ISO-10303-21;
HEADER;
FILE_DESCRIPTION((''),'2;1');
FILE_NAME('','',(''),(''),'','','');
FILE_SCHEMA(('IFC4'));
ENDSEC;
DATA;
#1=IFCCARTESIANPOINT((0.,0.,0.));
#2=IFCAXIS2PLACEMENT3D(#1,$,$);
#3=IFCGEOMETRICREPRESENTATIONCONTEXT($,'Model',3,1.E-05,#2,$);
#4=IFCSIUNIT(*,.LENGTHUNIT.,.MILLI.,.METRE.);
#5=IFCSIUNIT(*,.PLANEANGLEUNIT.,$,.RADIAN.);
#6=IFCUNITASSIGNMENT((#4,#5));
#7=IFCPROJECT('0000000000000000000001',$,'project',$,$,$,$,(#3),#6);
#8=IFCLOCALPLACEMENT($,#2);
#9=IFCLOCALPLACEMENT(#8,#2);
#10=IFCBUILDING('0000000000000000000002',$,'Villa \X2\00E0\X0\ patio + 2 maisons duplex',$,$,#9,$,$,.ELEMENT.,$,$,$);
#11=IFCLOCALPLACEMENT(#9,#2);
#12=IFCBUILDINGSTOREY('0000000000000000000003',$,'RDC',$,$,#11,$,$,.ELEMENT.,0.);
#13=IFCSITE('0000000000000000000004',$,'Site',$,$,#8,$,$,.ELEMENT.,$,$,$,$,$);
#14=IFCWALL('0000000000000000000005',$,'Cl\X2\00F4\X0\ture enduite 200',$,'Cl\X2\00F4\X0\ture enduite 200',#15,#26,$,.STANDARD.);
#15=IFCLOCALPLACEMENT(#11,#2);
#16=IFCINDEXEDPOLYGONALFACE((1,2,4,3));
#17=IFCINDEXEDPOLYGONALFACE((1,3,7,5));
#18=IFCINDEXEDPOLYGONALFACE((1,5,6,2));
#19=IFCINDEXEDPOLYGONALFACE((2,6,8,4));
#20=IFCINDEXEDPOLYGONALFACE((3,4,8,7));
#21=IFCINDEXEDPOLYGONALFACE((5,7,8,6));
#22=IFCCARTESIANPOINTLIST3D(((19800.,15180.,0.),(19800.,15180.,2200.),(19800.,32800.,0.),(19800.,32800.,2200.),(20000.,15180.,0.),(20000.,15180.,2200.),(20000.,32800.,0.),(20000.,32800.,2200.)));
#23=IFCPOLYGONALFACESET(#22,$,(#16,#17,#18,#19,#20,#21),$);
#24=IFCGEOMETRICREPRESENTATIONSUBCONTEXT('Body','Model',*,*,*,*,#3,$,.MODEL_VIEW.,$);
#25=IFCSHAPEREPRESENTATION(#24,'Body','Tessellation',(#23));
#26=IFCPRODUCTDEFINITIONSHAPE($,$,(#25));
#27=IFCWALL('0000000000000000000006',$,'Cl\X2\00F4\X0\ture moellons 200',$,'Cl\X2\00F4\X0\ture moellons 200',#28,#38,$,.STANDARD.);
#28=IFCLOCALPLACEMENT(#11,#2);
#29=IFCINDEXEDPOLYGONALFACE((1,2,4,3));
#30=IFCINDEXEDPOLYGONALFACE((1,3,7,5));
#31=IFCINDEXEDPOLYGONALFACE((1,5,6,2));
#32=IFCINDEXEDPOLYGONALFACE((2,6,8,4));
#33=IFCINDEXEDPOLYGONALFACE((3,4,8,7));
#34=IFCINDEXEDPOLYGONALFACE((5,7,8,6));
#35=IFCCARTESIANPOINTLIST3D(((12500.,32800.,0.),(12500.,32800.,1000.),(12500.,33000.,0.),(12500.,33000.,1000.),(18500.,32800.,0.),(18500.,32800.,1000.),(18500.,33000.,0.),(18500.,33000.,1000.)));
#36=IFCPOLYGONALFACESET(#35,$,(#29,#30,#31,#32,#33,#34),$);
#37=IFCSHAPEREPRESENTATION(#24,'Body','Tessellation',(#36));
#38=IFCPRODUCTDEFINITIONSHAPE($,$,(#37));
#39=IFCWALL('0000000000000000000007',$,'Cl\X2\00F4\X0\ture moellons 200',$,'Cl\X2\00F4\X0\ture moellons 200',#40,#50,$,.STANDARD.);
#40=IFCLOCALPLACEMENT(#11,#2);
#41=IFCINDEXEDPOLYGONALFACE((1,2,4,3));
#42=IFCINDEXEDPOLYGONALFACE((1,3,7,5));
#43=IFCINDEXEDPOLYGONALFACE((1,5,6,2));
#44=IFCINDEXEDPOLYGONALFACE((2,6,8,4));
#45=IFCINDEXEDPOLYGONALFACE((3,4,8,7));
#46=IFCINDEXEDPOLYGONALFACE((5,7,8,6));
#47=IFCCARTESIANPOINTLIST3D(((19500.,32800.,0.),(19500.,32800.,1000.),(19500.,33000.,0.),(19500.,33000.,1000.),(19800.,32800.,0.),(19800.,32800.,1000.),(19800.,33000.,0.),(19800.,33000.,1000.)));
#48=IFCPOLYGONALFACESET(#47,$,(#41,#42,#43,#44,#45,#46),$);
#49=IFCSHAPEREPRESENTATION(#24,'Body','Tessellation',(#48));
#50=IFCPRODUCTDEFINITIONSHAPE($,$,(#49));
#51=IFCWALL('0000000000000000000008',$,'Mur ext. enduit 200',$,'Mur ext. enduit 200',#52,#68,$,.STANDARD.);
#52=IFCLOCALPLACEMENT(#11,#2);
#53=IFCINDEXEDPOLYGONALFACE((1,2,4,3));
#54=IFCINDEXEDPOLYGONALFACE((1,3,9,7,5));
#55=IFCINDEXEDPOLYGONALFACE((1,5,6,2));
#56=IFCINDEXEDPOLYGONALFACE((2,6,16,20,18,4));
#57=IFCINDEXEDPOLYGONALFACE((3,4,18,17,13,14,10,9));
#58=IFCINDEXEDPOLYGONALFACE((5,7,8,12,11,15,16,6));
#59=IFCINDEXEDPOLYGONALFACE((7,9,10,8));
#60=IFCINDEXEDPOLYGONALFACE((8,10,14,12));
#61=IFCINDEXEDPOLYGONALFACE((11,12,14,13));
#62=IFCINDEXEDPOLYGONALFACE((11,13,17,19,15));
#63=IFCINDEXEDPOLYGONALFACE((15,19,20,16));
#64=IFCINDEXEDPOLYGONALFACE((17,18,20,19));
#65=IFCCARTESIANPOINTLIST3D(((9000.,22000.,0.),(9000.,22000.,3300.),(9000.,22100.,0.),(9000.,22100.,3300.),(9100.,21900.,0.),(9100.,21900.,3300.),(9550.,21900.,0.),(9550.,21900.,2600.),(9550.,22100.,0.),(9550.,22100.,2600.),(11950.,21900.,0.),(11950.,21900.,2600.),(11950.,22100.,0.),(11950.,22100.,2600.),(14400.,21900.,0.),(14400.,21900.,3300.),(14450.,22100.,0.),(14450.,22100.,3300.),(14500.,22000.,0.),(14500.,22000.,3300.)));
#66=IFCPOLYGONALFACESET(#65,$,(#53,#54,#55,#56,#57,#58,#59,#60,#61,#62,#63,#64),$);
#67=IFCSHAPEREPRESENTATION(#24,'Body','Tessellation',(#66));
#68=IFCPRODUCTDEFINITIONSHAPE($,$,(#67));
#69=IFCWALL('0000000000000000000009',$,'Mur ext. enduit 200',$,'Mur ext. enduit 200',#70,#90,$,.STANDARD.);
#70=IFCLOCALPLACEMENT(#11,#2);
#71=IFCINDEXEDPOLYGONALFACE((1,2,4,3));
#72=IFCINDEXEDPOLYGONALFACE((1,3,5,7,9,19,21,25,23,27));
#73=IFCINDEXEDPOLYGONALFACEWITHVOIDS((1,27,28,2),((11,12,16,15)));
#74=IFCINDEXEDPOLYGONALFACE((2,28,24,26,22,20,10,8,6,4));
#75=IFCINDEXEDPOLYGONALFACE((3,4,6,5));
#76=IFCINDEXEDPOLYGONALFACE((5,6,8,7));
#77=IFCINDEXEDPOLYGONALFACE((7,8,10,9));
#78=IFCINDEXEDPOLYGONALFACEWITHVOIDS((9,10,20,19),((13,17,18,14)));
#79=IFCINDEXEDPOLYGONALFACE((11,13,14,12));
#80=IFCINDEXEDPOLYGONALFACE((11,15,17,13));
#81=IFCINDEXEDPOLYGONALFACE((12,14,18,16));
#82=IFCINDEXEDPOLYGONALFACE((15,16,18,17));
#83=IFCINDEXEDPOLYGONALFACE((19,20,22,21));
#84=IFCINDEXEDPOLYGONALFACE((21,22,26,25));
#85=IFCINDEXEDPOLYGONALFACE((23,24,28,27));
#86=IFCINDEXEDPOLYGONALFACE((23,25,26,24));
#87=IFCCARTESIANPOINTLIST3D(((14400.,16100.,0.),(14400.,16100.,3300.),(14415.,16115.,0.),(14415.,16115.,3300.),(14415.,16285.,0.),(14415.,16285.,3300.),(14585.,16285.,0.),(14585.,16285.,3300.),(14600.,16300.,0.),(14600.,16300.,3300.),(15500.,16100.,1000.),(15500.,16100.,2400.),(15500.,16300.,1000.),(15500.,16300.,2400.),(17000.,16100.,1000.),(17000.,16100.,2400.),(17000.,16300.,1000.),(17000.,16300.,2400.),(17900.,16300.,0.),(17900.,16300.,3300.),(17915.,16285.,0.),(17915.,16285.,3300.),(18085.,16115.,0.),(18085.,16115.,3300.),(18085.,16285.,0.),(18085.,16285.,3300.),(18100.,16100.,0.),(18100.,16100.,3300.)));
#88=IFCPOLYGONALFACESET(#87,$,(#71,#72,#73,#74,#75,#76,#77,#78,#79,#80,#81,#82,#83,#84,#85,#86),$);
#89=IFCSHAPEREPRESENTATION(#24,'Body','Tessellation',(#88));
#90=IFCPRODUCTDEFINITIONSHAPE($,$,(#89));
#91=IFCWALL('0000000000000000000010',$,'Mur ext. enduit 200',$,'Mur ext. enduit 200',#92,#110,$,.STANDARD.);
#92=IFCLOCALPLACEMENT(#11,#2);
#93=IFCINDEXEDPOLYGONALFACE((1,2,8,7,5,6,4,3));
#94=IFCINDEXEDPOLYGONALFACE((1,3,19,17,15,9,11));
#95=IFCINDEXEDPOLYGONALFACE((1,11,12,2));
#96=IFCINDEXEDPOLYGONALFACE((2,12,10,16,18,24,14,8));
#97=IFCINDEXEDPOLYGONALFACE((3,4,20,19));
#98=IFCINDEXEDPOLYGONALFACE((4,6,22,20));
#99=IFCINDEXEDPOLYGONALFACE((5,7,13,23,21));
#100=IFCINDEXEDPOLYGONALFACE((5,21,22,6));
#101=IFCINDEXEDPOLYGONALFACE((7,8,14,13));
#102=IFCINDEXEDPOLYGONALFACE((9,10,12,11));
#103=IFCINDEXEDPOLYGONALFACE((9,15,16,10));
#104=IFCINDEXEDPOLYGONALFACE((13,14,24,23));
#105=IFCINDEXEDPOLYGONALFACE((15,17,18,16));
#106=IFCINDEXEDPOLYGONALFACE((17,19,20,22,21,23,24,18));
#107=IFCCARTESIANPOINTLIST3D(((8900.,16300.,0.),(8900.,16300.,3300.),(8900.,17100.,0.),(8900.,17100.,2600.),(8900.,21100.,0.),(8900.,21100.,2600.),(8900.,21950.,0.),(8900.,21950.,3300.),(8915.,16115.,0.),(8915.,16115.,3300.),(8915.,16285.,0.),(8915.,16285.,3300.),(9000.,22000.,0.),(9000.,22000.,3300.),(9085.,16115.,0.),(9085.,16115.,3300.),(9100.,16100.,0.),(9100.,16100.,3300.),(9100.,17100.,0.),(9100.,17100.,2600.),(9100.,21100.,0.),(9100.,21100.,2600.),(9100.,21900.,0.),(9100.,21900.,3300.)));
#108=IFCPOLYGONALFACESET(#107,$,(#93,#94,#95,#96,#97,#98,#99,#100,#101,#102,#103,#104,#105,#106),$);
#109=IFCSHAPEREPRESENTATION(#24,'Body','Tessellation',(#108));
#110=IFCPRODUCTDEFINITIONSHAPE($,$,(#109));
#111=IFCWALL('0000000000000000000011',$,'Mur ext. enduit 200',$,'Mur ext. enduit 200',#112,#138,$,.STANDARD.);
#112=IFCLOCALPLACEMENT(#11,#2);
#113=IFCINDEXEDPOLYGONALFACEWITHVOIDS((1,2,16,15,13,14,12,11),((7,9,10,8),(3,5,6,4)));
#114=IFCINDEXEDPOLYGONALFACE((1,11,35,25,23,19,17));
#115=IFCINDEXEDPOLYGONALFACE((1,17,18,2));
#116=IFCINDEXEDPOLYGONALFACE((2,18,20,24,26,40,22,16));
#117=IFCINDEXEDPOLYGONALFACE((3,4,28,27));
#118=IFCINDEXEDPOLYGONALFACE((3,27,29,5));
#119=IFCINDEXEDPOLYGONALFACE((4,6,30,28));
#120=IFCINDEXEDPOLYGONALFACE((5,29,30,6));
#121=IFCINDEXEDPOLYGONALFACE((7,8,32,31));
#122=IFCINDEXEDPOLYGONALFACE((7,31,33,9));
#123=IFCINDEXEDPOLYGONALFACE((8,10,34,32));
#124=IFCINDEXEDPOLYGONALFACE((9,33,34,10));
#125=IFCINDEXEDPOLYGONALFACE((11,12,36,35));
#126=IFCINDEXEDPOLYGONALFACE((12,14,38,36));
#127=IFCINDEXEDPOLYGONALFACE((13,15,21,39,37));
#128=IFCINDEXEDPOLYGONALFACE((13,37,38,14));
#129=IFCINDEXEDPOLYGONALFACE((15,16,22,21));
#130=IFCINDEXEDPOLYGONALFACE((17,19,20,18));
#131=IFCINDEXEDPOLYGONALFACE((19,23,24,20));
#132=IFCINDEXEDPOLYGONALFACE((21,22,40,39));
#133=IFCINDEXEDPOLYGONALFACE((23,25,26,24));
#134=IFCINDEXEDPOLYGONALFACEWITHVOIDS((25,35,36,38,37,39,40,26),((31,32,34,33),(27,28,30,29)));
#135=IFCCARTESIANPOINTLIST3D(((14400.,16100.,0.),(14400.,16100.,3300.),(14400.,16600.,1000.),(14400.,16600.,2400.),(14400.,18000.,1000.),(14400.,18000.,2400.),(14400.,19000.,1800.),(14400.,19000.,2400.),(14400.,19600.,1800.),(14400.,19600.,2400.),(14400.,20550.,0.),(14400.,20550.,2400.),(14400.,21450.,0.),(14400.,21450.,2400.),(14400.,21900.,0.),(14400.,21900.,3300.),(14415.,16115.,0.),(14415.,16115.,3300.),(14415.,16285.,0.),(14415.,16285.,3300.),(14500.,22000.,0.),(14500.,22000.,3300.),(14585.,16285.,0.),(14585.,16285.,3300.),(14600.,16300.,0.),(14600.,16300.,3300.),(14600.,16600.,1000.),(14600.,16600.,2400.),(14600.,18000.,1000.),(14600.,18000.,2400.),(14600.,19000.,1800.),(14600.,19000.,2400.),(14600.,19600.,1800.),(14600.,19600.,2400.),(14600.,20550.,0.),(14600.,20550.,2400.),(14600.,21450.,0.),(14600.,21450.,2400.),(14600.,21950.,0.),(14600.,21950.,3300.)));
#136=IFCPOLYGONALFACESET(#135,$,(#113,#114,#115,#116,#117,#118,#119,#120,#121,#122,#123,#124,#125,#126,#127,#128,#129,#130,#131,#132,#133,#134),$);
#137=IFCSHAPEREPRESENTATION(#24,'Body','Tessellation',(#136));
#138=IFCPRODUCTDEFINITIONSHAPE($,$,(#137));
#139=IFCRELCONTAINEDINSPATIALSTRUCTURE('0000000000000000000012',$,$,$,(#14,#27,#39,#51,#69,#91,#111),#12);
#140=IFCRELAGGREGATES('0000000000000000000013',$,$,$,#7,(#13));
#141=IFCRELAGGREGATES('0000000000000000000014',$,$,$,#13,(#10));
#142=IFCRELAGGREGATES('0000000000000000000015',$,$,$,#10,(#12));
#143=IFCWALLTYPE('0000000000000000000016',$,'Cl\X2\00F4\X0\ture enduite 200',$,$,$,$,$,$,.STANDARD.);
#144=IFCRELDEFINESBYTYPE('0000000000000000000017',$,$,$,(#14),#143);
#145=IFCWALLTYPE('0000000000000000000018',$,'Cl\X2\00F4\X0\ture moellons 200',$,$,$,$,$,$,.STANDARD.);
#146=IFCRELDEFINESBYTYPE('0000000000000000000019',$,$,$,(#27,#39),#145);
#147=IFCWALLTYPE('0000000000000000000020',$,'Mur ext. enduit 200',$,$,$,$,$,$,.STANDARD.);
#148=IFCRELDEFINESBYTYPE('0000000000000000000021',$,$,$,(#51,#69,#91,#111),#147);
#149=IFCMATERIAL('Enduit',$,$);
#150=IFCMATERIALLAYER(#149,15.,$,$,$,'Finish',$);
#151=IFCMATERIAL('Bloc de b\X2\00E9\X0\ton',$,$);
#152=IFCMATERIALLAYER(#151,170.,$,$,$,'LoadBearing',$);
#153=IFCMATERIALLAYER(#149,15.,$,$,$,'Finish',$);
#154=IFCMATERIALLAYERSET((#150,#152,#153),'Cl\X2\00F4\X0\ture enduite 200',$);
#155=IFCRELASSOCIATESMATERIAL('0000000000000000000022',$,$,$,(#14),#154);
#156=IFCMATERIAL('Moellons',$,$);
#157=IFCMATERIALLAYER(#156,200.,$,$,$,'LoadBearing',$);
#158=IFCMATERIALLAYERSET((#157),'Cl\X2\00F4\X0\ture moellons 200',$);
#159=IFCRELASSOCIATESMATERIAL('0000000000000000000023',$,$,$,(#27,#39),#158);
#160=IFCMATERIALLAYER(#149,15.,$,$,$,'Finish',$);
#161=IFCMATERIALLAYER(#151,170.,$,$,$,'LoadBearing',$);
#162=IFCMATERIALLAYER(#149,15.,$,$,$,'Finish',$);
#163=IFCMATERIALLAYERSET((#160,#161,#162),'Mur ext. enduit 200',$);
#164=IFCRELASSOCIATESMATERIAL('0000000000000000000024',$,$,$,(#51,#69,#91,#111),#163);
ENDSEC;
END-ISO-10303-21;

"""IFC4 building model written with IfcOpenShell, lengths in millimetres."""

from ifc_helpers import new_model, si_unit, frame, frame_2d, origin, place, context, subcontext, project, spatial, polyline, rectangle, outline, extrude, material, layer, layer_set, layer_usage, type_object, element, save


model = new_model("IFC4")

# Units and contexts
model_context = context("Model", 3, precision=1e-05, world=origin())
body_context = subcontext(model_context, "Body", "Model", "MODEL_VIEW")
ifc_project = project(units=[si_unit("LENGTHUNIT", "METRE", prefix="MILLI"), si_unit("PLANEANGLEUNIT", "RADIAN")], contexts=[model_context])

# Site, building, storey
site_placement = place(None, origin())
site = spatial("IfcSite", under=ifc_project, at=site_placement, Name="Site", CompositionType="ELEMENT")
building_placement = place(site_placement, origin())
building = spatial("IfcBuilding", under=site, at=building_placement, Name="Villa à patio + 2 maisons duplex", CompositionType="ELEMENT")
storey_placement = place(building_placement, origin())
storey = spatial("IfcBuildingStorey", under=building, at=storey_placement, Name="RDC", CompositionType="ELEMENT", Elevation=0.0)

# Shared definitions
ifc_material_1 = material(Name="Enduit")
ifc_material_2 = material(Name="Bloc de béton")

# Walls
ifc_layer_1 = layer(ifc_material_1, 15.0, Category="Finish")
ifc_layer_2 = layer(ifc_material_2, 170.0, Category="LoadBearing")
ifc_layer_3 = layer(ifc_material_1, 15.0, Category="Finish")
ifc_layer_set_1 = layer_set([ifc_layer_1, ifc_layer_2, ifc_layer_3], Name="Clôture enduite 200")
ifc_layer_usage_1 = layer_usage(ifc_layer_set_1, "AXIS2", "NEGATIVE", 100.0)
wall_type_1 = type_object("IfcWallType", Name="Clôture enduite 200", PredefinedType="STANDARD")
wall_1_placement = place(storey_placement, frame((19900.0, 33000.0, 0.0), z_axis=(0.0, 0.0, 1.0), x_axis=(0.0, -1.0, 0.0)))
element("IfcWall", 1, at=wall_1_placement, inside=storey, type_object=wall_type_1, material=ifc_layer_usage_1, Name="Clôture enduite 200", ObjectType="Clôture enduite 200", PredefinedType="STANDARD", context=body_context, shape_type="SweptSolid", body=[
    extrude(outline(polyline([(200.0, -100.0), (200.0, 100.0), (17820.0, 100.0), (17820.0, -100.0), (200.0, -100.0)])), origin(), (0.0, 0.0, 1.0), 2200.0),
])
ifc_material_3 = material(Name="Moellons")
ifc_layer_4 = layer(ifc_material_3, 200.0, Category="LoadBearing")
ifc_layer_set_2 = layer_set([ifc_layer_4], Name="Clôture moellons 200")
ifc_layer_usage_2 = layer_usage(ifc_layer_set_2, "AXIS2", "NEGATIVE", 100.0)
wall_type_2 = type_object("IfcWallType", Name="Clôture moellons 200", PredefinedType="STANDARD")
wall_2_placement = place(storey_placement, frame((12500.0, 32900.0, 0.0), z_axis=(0.0, 0.0, 1.0), x_axis=(1.0, 0.0, 0.0)))
element("IfcWall", 2, at=wall_2_placement, inside=storey, type_object=wall_type_2, material=ifc_layer_usage_2, Name="Clôture moellons 200", ObjectType="Clôture moellons 200", PredefinedType="STANDARD", context=body_context, shape_type="SweptSolid", body=[
    extrude(outline(polyline([(0.0, -100.0), (0.0, 100.0), (6000.0, 100.0), (6000.0, -100.0), (0.0, -100.0)])), origin(), (0.0, 0.0, 1.0), 1000.0),
])
wall_3_placement = place(storey_placement, frame((19500.0, 32900.0, 0.0), z_axis=(0.0, 0.0, 1.0), x_axis=(1.0, 0.0, 0.0)))
element("IfcWall", 3, at=wall_3_placement, inside=storey, type_object=wall_type_2, material=ifc_layer_usage_2, Name="Clôture moellons 200", ObjectType="Clôture moellons 200", PredefinedType="STANDARD", context=body_context, shape_type="SweptSolid", body=[
    extrude(outline(polyline([(0.0, -100.0), (0.0, 100.0), (300.0, 100.0), (300.0, -100.0), (0.0, -100.0)])), origin(), (0.0, 0.0, 1.0), 1000.0),
])

# Walls, openings
ifc_layer_5 = layer(ifc_material_1, 15.0, Category="Finish")
ifc_layer_6 = layer(ifc_material_2, 170.0, Category="LoadBearing")
ifc_layer_7 = layer(ifc_material_1, 15.0, Category="Finish")
ifc_layer_set_3 = layer_set([ifc_layer_5, ifc_layer_6, ifc_layer_7], Name="Mur ext. enduit 200")
ifc_layer_usage_3 = layer_usage(ifc_layer_set_3, "AXIS2", "NEGATIVE", 100.0)
wall_type_3 = type_object("IfcWallType", Name="Mur ext. enduit 200", PredefinedType="STANDARD")
wall_4_placement = place(storey_placement, frame((9000.0, 22000.0, 0.0), z_axis=(0.0, 0.0, 1.0), x_axis=(1.0, 0.0, 0.0)))
wall_4 = element("IfcWall", 4, at=wall_4_placement, inside=storey, type_object=wall_type_3, material=ifc_layer_usage_3, Name="Mur ext. enduit 200", ObjectType="Mur ext. enduit 200", PredefinedType="STANDARD", context=body_context, shape_type="SweptSolid", body=[
    extrude(outline(polyline([(100.0, -100.0), (0.0, 0.0), (0.0, 100.0), (5450.0, 100.0), (5500.0, 0.0), (5400.0, -100.0), (100.0, -100.0)])), origin(), (0.0, 0.0, 1.0), 3300.0),
])
opening_1_placement = place(wall_4_placement, frame((550.0, 0.0, 0.0), z_axis=(0.0, 0.0, 1.0), x_axis=(1.0, 0.0, 0.0)))
element("IfcOpeningElement", 5, at=opening_1_placement, cuts=wall_4, PredefinedType="OPENING", context=body_context, shape_type="SweptSolid", body=[
    extrude(rectangle(XDim=2400.0, YDim=220.0, at=frame_2d((1200.0, 0.0))), origin(), (0.0, 0.0, 1.0), 2600.0),
])
wall_5_placement = place(storey_placement, frame((14500.0, 16200.0, 0.0), z_axis=(0.0, 0.0, 1.0), x_axis=(1.0, 0.0, 0.0)))
wall_5 = element("IfcWall", 6, at=wall_5_placement, inside=storey, type_object=wall_type_3, material=ifc_layer_usage_3, Name="Mur ext. enduit 200", ObjectType="Mur ext. enduit 200", PredefinedType="STANDARD", context=body_context, shape_type="SweptSolid", body=[
    extrude(outline(polyline([(-100.0, -100.0), (-85.0, -85.0), (-85.0, 85.0), (85.0, 85.0), (100.0, 100.0), (3400.0, 100.0), (3415.0, 85.0), (3585.0, 85.0), (3585.0, -85.0), (3600.0, -100.0), (-100.0, -100.0)])), origin(), (0.0, 0.0, 1.0), 3300.0),
])
opening_2_placement = place(wall_5_placement, frame((1000.0, 0.0, 1000.0), z_axis=(0.0, 0.0, 1.0), x_axis=(1.0, 0.0, 0.0)))
element("IfcOpeningElement", 7, at=opening_2_placement, cuts=wall_5, PredefinedType="OPENING", context=body_context, shape_type="SweptSolid", body=[
    extrude(rectangle(XDim=1500.0, YDim=220.0, at=frame_2d((750.0, 0.0))), origin(), (0.0, 0.0, 1.0), 1400.0),
])
wall_6_placement = place(storey_placement, frame((9000.0, 22000.0, 0.0), z_axis=(0.0, 0.0, 1.0), x_axis=(0.0, -1.0, 0.0)))
wall_6 = element("IfcWall", 8, at=wall_6_placement, inside=storey, type_object=wall_type_3, material=ifc_layer_usage_3, Name="Mur ext. enduit 200", ObjectType="Mur ext. enduit 200", PredefinedType="STANDARD", context=body_context, shape_type="SweptSolid", body=[
    extrude(outline(polyline([(50.0, -100.0), (0.0, 0.0), (100.0, 100.0), (5900.0, 100.0), (5885.0, 85.0), (5885.0, -85.0), (5715.0, -85.0), (5700.0, -100.0), (50.0, -100.0)])), origin(), (0.0, 0.0, 1.0), 3300.0),
])
opening_3_placement = place(wall_6_placement, frame((900.0, 0.0, 0.0), z_axis=(0.0, 0.0, 1.0), x_axis=(1.0, 0.0, 0.0)))
element("IfcOpeningElement", 9, at=opening_3_placement, cuts=wall_6, PredefinedType="OPENING", context=body_context, shape_type="SweptSolid", body=[
    extrude(rectangle(XDim=4000.0, YDim=220.0, at=frame_2d((2000.0, 0.0))), origin(), (0.0, 0.0, 1.0), 2600.0),
])

# Wall, openings
wall_7_placement = place(storey_placement, frame((14500.0, 22000.0, 0.0), z_axis=(0.0, 0.0, 1.0), x_axis=(0.0, -1.0, 0.0)))
wall_7 = element("IfcWall", 10, at=wall_7_placement, inside=storey, type_object=wall_type_3, material=ifc_layer_usage_3, Name="Mur ext. enduit 200", ObjectType="Mur ext. enduit 200", PredefinedType="STANDARD", context=body_context, shape_type="SweptSolid", body=[
    extrude(outline(polyline([(100.0, -100.0), (0.0, 0.0), (50.0, 100.0), (5700.0, 100.0), (5715.0, 85.0), (5715.0, -85.0), (5885.0, -85.0), (5900.0, -100.0), (100.0, -100.0)])), origin(), (0.0, 0.0, 1.0), 3300.0),
])
opening_4_placement = place(wall_7_placement, frame((550.0, 0.0, 0.0), z_axis=(0.0, 0.0, 1.0), x_axis=(1.0, 0.0, 0.0)))
element("IfcOpeningElement", 11, at=opening_4_placement, cuts=wall_7, PredefinedType="OPENING", context=body_context, shape_type="SweptSolid", body=[
    extrude(rectangle(XDim=900.0, YDim=220.0, at=frame_2d((450.0, 0.0))), origin(), (0.0, 0.0, 1.0), 2400.0),
])
opening_5_placement = place(wall_7_placement, frame((2400.0, 0.0, 1800.0), z_axis=(0.0, 0.0, 1.0), x_axis=(1.0, 0.0, 0.0)))
element("IfcOpeningElement", 12, at=opening_5_placement, cuts=wall_7, PredefinedType="OPENING", context=body_context, shape_type="SweptSolid", body=[
    extrude(rectangle(XDim=600.0, YDim=220.0, at=frame_2d((300.0, 0.0))), origin(), (0.0, 0.0, 1.0), 600.0),
])
opening_6_placement = place(wall_7_placement, frame((4000.0, 0.0, 1000.0), z_axis=(0.0, 0.0, 1.0), x_axis=(1.0, 0.0, 0.0)))
element("IfcOpeningElement", 13, at=opening_6_placement, cuts=wall_7, PredefinedType="OPENING", context=body_context, shape_type="SweptSolid", body=[
    extrude(rectangle(XDim=1400.0, YDim=220.0, at=frame_2d((700.0, 0.0))), origin(), (0.0, 0.0, 1.0), 1400.0),
])

save(model, "model.ifc")
